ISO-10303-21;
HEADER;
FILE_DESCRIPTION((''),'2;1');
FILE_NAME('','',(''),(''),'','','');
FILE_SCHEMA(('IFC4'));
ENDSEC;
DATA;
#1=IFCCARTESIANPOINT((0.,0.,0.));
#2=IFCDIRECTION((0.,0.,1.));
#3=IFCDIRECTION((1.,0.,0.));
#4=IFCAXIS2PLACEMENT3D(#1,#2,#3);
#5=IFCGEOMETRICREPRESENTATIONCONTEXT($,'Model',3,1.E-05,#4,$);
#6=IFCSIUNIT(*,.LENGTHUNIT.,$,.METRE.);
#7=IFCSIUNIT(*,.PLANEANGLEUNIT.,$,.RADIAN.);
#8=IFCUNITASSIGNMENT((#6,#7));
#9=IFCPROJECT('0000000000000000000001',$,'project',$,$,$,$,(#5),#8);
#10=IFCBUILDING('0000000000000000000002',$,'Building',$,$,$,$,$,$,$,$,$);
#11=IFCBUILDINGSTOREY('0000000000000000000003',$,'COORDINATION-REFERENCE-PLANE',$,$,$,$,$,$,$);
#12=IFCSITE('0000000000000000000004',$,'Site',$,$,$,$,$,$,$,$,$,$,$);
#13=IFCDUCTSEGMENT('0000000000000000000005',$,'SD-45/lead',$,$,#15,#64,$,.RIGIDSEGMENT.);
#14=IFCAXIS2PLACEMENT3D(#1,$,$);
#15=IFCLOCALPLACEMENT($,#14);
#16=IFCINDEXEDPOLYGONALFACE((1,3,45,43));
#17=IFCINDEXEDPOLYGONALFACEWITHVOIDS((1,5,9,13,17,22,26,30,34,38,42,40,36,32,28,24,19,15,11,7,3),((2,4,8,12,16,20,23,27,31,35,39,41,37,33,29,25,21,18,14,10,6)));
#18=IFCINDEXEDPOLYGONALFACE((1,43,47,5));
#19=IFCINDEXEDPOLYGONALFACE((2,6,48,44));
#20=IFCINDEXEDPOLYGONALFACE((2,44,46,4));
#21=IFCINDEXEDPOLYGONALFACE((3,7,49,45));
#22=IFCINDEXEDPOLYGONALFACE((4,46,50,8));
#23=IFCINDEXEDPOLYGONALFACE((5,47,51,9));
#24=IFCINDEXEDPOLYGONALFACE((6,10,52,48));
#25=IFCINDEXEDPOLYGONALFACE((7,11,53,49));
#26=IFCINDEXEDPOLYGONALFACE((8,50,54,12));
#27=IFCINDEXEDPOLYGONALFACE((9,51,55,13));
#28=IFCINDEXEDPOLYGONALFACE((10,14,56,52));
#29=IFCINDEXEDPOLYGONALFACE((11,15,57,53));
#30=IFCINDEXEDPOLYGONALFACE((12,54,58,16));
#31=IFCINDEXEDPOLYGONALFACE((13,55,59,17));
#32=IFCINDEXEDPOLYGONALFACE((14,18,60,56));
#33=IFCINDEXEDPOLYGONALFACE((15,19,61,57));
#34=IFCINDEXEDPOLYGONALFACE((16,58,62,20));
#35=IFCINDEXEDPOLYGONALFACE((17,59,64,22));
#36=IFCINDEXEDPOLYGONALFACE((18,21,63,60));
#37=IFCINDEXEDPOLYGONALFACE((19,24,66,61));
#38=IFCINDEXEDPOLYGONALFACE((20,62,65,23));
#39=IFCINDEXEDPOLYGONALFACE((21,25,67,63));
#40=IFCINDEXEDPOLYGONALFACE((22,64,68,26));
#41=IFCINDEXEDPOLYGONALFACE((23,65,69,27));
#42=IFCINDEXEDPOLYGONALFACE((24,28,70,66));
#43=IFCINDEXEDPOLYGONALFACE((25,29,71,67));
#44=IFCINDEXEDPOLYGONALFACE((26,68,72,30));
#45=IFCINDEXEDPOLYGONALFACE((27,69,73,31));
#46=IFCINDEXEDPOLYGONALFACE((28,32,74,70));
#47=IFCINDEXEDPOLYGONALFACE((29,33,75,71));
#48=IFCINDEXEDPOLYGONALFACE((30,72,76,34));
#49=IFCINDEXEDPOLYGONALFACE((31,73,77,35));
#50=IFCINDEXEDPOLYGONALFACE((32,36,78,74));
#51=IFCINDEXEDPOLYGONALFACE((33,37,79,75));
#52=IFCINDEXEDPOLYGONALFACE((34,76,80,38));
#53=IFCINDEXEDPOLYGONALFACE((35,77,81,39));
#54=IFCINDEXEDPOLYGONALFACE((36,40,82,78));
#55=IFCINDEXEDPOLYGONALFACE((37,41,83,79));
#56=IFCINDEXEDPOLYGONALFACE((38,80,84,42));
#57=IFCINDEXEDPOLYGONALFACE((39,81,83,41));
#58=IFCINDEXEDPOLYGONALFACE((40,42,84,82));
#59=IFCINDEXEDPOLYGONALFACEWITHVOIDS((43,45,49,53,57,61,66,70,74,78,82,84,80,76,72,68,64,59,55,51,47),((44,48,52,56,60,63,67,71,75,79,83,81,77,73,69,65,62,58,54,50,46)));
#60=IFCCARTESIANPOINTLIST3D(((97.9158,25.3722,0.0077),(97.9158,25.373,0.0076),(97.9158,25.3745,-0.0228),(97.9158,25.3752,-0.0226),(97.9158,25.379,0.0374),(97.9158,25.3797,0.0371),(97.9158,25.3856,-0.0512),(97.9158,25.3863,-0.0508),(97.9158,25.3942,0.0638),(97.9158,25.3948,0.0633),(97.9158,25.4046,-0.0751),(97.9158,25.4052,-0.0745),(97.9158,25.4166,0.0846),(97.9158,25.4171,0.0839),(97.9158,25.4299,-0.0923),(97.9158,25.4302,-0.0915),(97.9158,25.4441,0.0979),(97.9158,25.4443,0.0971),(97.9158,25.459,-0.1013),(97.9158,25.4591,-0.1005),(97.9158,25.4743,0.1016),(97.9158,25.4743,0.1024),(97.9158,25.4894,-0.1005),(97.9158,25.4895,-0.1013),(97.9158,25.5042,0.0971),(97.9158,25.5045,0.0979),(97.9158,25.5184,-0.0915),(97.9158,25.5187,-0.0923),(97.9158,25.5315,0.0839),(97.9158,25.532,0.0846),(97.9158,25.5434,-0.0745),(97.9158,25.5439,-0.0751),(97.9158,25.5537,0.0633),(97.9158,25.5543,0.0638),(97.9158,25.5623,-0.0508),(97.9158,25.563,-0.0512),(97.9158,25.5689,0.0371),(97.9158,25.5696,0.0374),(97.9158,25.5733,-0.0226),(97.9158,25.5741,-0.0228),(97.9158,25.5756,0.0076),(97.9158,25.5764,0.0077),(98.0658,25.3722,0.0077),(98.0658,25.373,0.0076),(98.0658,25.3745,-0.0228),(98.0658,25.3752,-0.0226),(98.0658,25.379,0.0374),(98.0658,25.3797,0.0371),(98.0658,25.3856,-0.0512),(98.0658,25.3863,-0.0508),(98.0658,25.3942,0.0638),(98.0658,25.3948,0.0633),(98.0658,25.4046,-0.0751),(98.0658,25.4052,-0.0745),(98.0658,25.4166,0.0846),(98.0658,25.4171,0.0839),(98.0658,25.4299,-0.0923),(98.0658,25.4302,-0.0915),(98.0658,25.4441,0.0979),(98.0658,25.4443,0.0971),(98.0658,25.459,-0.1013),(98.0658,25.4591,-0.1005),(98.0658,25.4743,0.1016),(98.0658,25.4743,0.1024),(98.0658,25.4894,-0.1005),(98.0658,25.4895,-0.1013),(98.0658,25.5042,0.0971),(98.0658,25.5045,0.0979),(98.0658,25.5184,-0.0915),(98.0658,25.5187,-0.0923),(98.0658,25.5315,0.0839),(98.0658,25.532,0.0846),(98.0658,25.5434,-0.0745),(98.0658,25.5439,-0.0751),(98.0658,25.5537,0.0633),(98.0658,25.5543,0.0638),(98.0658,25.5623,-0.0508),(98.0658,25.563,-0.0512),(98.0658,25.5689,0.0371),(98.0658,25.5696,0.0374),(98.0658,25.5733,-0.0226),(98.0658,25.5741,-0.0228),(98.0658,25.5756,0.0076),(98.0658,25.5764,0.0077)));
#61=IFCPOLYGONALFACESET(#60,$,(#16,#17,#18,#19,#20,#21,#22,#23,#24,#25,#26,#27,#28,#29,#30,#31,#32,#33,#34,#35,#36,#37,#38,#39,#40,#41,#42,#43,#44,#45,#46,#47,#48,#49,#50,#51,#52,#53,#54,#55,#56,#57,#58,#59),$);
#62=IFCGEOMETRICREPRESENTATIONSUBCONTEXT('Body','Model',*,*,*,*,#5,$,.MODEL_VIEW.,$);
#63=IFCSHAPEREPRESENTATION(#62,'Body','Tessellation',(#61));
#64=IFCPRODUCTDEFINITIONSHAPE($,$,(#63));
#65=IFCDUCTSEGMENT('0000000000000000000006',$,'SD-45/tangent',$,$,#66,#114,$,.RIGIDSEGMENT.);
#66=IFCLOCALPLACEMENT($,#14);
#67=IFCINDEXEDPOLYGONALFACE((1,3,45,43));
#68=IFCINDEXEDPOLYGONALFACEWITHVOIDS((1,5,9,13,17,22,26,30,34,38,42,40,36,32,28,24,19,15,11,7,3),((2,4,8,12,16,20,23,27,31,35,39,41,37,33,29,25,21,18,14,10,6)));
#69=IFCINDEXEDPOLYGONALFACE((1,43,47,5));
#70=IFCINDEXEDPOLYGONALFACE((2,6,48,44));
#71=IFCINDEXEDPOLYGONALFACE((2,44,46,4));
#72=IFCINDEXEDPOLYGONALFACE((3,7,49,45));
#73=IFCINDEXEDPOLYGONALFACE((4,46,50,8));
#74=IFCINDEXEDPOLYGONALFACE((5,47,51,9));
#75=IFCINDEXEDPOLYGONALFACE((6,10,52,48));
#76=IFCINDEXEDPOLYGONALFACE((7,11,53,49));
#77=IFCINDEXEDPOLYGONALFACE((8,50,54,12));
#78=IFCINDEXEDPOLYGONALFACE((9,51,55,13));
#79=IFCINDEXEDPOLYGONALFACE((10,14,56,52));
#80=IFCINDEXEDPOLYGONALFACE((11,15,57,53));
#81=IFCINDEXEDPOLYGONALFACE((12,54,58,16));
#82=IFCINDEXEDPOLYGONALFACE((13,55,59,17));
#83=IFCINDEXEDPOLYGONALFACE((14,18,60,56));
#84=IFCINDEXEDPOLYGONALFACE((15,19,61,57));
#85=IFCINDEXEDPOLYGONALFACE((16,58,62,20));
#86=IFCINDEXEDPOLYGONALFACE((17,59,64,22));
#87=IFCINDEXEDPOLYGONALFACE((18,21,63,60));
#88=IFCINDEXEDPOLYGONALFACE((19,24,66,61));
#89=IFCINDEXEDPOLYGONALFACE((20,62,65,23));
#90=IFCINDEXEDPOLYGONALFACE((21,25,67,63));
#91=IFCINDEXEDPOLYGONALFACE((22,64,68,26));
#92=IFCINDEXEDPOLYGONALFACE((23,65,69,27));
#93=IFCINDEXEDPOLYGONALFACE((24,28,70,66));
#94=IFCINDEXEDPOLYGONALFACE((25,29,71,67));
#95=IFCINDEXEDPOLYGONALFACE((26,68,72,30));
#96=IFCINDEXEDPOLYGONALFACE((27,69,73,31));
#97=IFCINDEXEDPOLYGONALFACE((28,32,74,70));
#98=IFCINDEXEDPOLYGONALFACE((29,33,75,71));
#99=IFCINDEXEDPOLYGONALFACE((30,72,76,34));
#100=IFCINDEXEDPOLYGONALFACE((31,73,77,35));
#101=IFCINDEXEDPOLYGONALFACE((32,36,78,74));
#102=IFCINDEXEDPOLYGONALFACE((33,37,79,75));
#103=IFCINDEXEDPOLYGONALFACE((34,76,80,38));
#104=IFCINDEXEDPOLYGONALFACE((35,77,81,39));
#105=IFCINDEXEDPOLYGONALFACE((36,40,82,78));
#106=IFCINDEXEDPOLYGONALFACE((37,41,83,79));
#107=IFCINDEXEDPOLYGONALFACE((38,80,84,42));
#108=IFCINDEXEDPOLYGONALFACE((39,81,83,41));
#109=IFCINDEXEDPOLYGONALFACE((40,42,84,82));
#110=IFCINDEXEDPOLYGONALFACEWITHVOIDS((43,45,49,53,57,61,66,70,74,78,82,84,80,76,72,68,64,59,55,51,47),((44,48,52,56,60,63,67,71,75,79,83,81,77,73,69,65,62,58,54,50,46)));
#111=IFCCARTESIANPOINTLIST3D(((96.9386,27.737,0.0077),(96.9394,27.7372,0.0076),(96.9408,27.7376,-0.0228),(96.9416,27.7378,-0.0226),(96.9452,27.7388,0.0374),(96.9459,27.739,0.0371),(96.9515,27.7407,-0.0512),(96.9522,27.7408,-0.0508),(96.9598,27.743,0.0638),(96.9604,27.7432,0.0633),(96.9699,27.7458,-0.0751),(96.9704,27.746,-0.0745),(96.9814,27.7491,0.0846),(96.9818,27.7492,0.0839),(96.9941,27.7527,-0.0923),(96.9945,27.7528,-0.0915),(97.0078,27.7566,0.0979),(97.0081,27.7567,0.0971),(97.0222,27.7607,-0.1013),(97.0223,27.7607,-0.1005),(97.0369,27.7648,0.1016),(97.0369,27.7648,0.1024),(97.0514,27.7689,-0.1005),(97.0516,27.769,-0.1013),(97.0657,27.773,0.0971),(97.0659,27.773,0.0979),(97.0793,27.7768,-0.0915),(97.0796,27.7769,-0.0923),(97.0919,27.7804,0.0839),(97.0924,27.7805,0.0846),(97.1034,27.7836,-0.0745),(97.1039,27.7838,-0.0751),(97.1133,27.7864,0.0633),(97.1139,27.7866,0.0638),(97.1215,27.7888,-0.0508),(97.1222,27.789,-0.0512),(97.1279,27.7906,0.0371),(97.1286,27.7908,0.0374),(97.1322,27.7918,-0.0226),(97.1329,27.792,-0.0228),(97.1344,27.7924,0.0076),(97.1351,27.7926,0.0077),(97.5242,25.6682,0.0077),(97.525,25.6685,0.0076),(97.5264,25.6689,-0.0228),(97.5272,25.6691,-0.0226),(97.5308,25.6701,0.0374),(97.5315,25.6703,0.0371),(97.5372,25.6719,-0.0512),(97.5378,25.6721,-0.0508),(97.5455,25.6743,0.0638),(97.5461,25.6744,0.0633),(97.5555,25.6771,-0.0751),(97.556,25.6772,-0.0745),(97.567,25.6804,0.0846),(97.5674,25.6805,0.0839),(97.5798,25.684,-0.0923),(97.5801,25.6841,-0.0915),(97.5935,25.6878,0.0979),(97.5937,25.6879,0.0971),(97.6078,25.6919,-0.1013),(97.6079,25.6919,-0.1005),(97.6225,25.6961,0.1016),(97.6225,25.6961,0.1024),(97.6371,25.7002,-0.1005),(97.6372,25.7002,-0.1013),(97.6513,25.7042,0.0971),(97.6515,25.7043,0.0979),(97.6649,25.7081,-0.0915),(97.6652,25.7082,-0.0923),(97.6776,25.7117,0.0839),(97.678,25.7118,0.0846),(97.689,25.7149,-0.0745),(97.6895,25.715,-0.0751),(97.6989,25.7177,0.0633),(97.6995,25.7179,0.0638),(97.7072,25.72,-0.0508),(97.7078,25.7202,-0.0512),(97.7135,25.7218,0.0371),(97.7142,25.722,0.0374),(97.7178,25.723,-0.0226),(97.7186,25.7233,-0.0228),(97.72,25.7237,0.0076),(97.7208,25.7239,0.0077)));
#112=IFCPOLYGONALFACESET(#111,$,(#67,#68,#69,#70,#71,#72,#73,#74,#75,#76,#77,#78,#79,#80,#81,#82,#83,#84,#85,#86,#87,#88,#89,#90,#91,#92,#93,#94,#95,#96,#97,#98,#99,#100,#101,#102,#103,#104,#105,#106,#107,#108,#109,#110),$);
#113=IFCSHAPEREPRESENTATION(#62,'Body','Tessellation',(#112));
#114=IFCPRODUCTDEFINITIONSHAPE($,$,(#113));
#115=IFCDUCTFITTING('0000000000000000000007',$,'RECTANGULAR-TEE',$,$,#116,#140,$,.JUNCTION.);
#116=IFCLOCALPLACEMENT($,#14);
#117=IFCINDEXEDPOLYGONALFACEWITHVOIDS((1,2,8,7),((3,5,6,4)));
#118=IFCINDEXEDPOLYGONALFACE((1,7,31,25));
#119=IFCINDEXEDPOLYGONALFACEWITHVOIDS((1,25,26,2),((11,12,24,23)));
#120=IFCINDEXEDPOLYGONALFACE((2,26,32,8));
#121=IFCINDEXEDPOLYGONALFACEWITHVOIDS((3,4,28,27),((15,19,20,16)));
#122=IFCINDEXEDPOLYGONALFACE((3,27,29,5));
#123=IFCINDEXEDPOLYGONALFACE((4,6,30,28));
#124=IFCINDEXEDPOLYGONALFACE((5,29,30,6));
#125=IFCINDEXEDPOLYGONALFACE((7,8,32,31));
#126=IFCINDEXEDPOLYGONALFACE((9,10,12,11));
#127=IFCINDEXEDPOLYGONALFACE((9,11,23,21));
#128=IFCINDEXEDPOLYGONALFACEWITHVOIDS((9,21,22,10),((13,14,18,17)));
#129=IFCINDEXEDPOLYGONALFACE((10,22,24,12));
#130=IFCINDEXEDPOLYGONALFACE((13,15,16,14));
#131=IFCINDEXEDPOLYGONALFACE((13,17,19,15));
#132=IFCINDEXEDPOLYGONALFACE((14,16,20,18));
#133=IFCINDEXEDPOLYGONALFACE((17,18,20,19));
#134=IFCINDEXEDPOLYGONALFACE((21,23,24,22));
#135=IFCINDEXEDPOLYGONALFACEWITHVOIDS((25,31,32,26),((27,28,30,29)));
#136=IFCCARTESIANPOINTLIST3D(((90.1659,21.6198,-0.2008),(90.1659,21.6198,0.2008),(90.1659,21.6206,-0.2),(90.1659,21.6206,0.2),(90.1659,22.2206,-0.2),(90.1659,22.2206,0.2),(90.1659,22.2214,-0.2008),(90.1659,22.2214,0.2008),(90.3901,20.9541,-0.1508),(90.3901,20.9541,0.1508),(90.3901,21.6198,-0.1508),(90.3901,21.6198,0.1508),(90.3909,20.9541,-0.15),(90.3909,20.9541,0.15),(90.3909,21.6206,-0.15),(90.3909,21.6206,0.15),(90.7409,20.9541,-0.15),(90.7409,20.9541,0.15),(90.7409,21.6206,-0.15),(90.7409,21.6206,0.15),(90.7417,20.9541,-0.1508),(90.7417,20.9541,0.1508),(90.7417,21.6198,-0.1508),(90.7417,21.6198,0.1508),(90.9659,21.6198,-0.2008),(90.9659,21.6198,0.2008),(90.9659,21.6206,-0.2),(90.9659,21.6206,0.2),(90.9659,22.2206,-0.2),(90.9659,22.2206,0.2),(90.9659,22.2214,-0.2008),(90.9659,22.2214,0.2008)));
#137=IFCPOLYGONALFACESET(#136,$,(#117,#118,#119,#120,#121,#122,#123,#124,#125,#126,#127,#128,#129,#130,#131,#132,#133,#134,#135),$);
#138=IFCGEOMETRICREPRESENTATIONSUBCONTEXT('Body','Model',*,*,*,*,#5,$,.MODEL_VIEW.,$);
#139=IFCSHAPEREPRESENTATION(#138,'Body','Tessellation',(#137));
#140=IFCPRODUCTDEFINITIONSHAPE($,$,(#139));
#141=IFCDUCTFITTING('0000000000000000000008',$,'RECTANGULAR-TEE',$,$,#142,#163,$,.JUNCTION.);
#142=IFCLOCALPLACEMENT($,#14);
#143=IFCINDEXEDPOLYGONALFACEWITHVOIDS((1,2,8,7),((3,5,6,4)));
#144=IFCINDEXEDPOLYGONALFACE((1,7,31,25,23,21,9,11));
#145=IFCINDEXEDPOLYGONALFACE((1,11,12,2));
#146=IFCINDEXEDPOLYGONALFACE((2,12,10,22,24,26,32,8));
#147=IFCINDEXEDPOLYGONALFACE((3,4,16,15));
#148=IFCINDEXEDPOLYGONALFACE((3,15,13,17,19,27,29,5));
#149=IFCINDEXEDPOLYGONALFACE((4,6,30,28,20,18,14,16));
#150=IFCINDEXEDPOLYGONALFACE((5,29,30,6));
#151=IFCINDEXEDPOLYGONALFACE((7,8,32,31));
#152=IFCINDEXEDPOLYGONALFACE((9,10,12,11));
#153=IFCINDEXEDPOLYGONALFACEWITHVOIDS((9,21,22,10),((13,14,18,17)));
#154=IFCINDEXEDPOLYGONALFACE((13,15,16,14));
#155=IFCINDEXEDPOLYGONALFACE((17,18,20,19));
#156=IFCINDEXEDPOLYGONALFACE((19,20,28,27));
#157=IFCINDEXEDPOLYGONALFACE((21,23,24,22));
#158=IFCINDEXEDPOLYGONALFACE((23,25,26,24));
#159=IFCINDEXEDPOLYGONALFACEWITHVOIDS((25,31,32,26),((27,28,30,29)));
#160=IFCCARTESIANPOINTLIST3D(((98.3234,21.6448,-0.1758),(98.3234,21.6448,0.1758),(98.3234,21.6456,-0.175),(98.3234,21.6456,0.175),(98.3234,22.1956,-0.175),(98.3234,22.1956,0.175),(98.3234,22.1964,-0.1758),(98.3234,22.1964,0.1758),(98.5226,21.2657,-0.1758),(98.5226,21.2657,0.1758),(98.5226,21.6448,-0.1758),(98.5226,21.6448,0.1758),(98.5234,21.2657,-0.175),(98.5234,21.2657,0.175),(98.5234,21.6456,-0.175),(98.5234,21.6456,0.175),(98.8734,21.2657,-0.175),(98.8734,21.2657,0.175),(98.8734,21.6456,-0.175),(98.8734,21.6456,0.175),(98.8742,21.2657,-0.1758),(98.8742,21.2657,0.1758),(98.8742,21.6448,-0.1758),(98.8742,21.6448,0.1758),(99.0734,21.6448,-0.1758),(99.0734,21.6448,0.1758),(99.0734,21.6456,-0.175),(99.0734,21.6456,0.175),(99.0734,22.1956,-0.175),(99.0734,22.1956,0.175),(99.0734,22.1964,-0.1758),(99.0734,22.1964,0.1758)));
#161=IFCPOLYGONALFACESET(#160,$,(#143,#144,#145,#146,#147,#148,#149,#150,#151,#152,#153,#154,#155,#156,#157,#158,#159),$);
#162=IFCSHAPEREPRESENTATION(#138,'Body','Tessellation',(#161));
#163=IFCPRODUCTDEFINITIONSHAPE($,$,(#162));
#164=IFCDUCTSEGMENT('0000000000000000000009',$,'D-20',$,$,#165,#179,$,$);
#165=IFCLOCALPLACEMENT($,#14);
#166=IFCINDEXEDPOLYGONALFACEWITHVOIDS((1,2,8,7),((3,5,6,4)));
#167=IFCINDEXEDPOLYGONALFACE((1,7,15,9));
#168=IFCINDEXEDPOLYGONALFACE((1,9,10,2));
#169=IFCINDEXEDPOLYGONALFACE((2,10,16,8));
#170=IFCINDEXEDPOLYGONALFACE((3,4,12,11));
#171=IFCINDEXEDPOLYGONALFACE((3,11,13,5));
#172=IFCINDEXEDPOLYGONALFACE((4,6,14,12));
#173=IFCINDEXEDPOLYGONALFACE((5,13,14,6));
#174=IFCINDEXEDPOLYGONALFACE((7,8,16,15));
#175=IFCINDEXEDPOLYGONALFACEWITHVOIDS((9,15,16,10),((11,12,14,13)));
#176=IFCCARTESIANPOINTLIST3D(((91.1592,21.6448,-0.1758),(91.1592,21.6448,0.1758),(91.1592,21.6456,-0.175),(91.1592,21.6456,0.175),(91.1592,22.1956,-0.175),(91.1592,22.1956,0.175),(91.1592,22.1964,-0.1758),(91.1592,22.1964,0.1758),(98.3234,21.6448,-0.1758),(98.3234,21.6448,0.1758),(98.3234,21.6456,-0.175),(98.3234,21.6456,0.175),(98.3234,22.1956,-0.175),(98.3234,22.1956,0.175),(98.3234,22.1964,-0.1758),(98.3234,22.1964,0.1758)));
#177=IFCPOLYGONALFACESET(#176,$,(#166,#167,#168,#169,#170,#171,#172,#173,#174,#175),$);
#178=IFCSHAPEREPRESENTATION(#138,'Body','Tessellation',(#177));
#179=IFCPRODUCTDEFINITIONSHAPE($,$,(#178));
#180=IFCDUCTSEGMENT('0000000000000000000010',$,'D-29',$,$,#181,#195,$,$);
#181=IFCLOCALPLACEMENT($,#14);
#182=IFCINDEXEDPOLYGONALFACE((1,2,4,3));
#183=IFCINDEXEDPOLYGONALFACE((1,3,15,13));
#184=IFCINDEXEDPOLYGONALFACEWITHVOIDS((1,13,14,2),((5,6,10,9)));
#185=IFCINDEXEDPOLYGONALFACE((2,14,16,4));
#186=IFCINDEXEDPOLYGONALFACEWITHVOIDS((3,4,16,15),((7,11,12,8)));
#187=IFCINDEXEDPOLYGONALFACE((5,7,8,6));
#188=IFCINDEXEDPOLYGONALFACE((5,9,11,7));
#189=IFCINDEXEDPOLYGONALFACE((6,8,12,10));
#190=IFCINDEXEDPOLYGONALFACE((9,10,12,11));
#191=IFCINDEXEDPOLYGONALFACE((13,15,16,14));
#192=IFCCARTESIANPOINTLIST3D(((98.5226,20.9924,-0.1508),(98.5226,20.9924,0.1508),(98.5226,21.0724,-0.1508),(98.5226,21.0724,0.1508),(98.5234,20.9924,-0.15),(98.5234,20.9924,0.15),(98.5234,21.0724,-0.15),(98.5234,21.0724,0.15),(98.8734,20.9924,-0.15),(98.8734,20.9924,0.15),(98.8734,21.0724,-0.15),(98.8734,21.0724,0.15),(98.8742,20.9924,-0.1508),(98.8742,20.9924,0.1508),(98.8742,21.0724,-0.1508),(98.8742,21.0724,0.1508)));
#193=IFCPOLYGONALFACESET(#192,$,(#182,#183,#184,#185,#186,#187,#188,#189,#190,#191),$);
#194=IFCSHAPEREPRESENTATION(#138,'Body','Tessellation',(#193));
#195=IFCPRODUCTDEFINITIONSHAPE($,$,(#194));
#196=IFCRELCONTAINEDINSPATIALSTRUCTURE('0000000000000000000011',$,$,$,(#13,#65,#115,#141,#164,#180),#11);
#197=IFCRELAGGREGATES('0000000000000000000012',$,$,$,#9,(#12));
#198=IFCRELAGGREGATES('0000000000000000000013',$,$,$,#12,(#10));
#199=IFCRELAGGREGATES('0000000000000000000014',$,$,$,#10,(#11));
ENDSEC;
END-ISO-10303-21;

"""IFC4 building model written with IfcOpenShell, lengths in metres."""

from ifc_helpers import new_model, si_unit, frame, origin, origin_with_axes, place, context, subcontext, project, spatial, rectangle, hollow_rectangle, hollow_circle, extrude, boolean, element, save


model = new_model("IFC4")

# Units and contexts
model_context = context("Model", 3, precision=1e-05, world=origin_with_axes())
body_context_1 = subcontext(model_context, "Body", "Model", "MODEL_VIEW")
body_context_2 = subcontext(model_context, "Body", "Model", "MODEL_VIEW")
ifc_project = project(units=[si_unit("LENGTHUNIT", "METRE"), si_unit("PLANEANGLEUNIT", "RADIAN")], contexts=[model_context])

# Site, building, storey
site = spatial("IfcSite", under=ifc_project, Name="Site")
building = spatial("IfcBuilding", under=site, Name="Building")
storey = spatial("IfcBuildingStorey", under=building, Name="COORDINATION-REFERENCE-PLANE")

# Duct segment
duct_segment_1_placement = place(None, frame((98.0658, 25.4743, 0.0), z_axis=(-1.0, 0.0, 0.0), x_axis=(0.0, 0.0, 1.0)))
element("IfcDuctSegment", 1, at=duct_segment_1_placement, inside=storey, Name="SD-45/lead", PredefinedType="RIGIDSEGMENT", context=body_context_1, shape_type="SweptSolid", body=[
    extrude(hollow_circle(Radius=0.1024, WallThickness=0.0008), origin_with_axes(), (0.0, 0.0, 1.0), 0.15),
])

# Duct segment
duct_segment_2_placement = place(None, frame((97.6225, 25.6961, 0.0), z_axis=(-0.272381, 0.96219, 0.0), x_axis=(0.0, 0.0, 1.0)))
element("IfcDuctSegment", 2, at=duct_segment_2_placement, inside=storey, Name="SD-45/tangent", PredefinedType="RIGIDSEGMENT", context=body_context_1, shape_type="SweptSolid", body=[
    extrude(hollow_circle(Radius=0.1024, WallThickness=0.0008), origin_with_axes(), (0.0, 0.0, 1.0), 2.15),
])

# Duct fittings
duct_fitting_1_placement = place(None, frame((90.5659, 21.9206, 0.0), z_axis=(1.0, 0.0, 0.0), x_axis=(0.0, -1.0, 0.0)))
solid_1 = boolean("UNION", extrude(rectangle(XDim=0.6, YDim=0.4), frame((0.0, 0.0, -0.4), z_axis=(0.0, 0.0, 1.0), x_axis=(1.0, 0.0, 0.0)), (0.0, 0.0, 1.0), 0.8), extrude(rectangle(XDim=0.35, YDim=0.3), frame((0.0, 0.0, 0.0), z_axis=(1.0, 0.0, 0.0), x_axis=(0.0, 0.0, -1.0)), (0.0, 0.0, 1.0), 0.9665))
element("IfcDuctFitting", 3, at=duct_fitting_1_placement, inside=storey, Name="RECTANGULAR-TEE", PredefinedType="JUNCTION", context=body_context_2, shape_type="CSG", body=[
    boolean("DIFFERENCE", boolean("UNION", extrude(rectangle(XDim=0.6016, YDim=0.4016), frame((0.0, 0.0, -0.4), z_axis=(0.0, 0.0, 1.0), x_axis=(1.0, 0.0, 0.0)), (0.0, 0.0, 1.0), 0.8), extrude(rectangle(XDim=0.3516, YDim=0.3016), frame((0.0, 0.0, 0.0), z_axis=(1.0, 0.0, 0.0), x_axis=(0.0, 0.0, -1.0)), (0.0, 0.0, 1.0), 0.9665)), solid_1),
])
duct_fitting_2_placement = place(None, frame((98.6984, 21.9206, 0.0), z_axis=(1.0, 0.0, 0.0), x_axis=(0.0, -1.0, 0.0)))
solid_2 = boolean("UNION", extrude(rectangle(XDim=0.55, YDim=0.35), frame((0.0, 0.0, -0.375), z_axis=(0.0, 0.0, 1.0), x_axis=(1.0, 0.0, 0.0)), (0.0, 0.0, 1.0), 0.75), extrude(rectangle(XDim=0.35, YDim=0.35), frame((0.0, 0.0, 0.0), z_axis=(1.0, 0.0, 0.0), x_axis=(0.0, 0.0, -1.0)), (0.0, 0.0, 1.0), 0.6549))
element("IfcDuctFitting", 4, at=duct_fitting_2_placement, inside=storey, Name="RECTANGULAR-TEE", PredefinedType="JUNCTION", context=body_context_2, shape_type="CSG", body=[
    boolean("DIFFERENCE", boolean("UNION", extrude(rectangle(XDim=0.5516, YDim=0.3516), frame((0.0, 0.0, -0.375), z_axis=(0.0, 0.0, 1.0), x_axis=(1.0, 0.0, 0.0)), (0.0, 0.0, 1.0), 0.75), extrude(rectangle(XDim=0.3516, YDim=0.3516), frame((0.0, 0.0, 0.0), z_axis=(1.0, 0.0, 0.0), x_axis=(0.0, 0.0, -1.0)), (0.0, 0.0, 1.0), 0.6549)), solid_2),
])

# Duct segments
duct_segment_3_placement = place(None, frame((91.1592, 21.9206, 0.0), z_axis=(1.0, 0.0, 0.0), x_axis=(0.0, 1.0, 0.0)))
element("IfcDuctSegment", 5, at=duct_segment_3_placement, inside=storey, Name="D-20", context=body_context_2, shape_type="SweptSolid", body=[
    extrude(hollow_rectangle(XDim=0.5516, YDim=0.3516, WallThickness=0.0008), origin(), (0.0, 0.0, 1.0), 7.1642),
])
duct_segment_4_placement = place(None, frame((98.6984, 20.9924, 0.0), z_axis=(0.0, 1.0, 0.0), x_axis=(1.0, 0.0, 0.0)))
element("IfcDuctSegment", 6, at=duct_segment_4_placement, inside=storey, Name="D-29", context=body_context_2, shape_type="SweptSolid", body=[
    extrude(hollow_rectangle(XDim=0.3516, YDim=0.3016, WallThickness=0.0008), origin(), (0.0, 0.0, 1.0), 0.08),
])

save(model, "model.ifc")
